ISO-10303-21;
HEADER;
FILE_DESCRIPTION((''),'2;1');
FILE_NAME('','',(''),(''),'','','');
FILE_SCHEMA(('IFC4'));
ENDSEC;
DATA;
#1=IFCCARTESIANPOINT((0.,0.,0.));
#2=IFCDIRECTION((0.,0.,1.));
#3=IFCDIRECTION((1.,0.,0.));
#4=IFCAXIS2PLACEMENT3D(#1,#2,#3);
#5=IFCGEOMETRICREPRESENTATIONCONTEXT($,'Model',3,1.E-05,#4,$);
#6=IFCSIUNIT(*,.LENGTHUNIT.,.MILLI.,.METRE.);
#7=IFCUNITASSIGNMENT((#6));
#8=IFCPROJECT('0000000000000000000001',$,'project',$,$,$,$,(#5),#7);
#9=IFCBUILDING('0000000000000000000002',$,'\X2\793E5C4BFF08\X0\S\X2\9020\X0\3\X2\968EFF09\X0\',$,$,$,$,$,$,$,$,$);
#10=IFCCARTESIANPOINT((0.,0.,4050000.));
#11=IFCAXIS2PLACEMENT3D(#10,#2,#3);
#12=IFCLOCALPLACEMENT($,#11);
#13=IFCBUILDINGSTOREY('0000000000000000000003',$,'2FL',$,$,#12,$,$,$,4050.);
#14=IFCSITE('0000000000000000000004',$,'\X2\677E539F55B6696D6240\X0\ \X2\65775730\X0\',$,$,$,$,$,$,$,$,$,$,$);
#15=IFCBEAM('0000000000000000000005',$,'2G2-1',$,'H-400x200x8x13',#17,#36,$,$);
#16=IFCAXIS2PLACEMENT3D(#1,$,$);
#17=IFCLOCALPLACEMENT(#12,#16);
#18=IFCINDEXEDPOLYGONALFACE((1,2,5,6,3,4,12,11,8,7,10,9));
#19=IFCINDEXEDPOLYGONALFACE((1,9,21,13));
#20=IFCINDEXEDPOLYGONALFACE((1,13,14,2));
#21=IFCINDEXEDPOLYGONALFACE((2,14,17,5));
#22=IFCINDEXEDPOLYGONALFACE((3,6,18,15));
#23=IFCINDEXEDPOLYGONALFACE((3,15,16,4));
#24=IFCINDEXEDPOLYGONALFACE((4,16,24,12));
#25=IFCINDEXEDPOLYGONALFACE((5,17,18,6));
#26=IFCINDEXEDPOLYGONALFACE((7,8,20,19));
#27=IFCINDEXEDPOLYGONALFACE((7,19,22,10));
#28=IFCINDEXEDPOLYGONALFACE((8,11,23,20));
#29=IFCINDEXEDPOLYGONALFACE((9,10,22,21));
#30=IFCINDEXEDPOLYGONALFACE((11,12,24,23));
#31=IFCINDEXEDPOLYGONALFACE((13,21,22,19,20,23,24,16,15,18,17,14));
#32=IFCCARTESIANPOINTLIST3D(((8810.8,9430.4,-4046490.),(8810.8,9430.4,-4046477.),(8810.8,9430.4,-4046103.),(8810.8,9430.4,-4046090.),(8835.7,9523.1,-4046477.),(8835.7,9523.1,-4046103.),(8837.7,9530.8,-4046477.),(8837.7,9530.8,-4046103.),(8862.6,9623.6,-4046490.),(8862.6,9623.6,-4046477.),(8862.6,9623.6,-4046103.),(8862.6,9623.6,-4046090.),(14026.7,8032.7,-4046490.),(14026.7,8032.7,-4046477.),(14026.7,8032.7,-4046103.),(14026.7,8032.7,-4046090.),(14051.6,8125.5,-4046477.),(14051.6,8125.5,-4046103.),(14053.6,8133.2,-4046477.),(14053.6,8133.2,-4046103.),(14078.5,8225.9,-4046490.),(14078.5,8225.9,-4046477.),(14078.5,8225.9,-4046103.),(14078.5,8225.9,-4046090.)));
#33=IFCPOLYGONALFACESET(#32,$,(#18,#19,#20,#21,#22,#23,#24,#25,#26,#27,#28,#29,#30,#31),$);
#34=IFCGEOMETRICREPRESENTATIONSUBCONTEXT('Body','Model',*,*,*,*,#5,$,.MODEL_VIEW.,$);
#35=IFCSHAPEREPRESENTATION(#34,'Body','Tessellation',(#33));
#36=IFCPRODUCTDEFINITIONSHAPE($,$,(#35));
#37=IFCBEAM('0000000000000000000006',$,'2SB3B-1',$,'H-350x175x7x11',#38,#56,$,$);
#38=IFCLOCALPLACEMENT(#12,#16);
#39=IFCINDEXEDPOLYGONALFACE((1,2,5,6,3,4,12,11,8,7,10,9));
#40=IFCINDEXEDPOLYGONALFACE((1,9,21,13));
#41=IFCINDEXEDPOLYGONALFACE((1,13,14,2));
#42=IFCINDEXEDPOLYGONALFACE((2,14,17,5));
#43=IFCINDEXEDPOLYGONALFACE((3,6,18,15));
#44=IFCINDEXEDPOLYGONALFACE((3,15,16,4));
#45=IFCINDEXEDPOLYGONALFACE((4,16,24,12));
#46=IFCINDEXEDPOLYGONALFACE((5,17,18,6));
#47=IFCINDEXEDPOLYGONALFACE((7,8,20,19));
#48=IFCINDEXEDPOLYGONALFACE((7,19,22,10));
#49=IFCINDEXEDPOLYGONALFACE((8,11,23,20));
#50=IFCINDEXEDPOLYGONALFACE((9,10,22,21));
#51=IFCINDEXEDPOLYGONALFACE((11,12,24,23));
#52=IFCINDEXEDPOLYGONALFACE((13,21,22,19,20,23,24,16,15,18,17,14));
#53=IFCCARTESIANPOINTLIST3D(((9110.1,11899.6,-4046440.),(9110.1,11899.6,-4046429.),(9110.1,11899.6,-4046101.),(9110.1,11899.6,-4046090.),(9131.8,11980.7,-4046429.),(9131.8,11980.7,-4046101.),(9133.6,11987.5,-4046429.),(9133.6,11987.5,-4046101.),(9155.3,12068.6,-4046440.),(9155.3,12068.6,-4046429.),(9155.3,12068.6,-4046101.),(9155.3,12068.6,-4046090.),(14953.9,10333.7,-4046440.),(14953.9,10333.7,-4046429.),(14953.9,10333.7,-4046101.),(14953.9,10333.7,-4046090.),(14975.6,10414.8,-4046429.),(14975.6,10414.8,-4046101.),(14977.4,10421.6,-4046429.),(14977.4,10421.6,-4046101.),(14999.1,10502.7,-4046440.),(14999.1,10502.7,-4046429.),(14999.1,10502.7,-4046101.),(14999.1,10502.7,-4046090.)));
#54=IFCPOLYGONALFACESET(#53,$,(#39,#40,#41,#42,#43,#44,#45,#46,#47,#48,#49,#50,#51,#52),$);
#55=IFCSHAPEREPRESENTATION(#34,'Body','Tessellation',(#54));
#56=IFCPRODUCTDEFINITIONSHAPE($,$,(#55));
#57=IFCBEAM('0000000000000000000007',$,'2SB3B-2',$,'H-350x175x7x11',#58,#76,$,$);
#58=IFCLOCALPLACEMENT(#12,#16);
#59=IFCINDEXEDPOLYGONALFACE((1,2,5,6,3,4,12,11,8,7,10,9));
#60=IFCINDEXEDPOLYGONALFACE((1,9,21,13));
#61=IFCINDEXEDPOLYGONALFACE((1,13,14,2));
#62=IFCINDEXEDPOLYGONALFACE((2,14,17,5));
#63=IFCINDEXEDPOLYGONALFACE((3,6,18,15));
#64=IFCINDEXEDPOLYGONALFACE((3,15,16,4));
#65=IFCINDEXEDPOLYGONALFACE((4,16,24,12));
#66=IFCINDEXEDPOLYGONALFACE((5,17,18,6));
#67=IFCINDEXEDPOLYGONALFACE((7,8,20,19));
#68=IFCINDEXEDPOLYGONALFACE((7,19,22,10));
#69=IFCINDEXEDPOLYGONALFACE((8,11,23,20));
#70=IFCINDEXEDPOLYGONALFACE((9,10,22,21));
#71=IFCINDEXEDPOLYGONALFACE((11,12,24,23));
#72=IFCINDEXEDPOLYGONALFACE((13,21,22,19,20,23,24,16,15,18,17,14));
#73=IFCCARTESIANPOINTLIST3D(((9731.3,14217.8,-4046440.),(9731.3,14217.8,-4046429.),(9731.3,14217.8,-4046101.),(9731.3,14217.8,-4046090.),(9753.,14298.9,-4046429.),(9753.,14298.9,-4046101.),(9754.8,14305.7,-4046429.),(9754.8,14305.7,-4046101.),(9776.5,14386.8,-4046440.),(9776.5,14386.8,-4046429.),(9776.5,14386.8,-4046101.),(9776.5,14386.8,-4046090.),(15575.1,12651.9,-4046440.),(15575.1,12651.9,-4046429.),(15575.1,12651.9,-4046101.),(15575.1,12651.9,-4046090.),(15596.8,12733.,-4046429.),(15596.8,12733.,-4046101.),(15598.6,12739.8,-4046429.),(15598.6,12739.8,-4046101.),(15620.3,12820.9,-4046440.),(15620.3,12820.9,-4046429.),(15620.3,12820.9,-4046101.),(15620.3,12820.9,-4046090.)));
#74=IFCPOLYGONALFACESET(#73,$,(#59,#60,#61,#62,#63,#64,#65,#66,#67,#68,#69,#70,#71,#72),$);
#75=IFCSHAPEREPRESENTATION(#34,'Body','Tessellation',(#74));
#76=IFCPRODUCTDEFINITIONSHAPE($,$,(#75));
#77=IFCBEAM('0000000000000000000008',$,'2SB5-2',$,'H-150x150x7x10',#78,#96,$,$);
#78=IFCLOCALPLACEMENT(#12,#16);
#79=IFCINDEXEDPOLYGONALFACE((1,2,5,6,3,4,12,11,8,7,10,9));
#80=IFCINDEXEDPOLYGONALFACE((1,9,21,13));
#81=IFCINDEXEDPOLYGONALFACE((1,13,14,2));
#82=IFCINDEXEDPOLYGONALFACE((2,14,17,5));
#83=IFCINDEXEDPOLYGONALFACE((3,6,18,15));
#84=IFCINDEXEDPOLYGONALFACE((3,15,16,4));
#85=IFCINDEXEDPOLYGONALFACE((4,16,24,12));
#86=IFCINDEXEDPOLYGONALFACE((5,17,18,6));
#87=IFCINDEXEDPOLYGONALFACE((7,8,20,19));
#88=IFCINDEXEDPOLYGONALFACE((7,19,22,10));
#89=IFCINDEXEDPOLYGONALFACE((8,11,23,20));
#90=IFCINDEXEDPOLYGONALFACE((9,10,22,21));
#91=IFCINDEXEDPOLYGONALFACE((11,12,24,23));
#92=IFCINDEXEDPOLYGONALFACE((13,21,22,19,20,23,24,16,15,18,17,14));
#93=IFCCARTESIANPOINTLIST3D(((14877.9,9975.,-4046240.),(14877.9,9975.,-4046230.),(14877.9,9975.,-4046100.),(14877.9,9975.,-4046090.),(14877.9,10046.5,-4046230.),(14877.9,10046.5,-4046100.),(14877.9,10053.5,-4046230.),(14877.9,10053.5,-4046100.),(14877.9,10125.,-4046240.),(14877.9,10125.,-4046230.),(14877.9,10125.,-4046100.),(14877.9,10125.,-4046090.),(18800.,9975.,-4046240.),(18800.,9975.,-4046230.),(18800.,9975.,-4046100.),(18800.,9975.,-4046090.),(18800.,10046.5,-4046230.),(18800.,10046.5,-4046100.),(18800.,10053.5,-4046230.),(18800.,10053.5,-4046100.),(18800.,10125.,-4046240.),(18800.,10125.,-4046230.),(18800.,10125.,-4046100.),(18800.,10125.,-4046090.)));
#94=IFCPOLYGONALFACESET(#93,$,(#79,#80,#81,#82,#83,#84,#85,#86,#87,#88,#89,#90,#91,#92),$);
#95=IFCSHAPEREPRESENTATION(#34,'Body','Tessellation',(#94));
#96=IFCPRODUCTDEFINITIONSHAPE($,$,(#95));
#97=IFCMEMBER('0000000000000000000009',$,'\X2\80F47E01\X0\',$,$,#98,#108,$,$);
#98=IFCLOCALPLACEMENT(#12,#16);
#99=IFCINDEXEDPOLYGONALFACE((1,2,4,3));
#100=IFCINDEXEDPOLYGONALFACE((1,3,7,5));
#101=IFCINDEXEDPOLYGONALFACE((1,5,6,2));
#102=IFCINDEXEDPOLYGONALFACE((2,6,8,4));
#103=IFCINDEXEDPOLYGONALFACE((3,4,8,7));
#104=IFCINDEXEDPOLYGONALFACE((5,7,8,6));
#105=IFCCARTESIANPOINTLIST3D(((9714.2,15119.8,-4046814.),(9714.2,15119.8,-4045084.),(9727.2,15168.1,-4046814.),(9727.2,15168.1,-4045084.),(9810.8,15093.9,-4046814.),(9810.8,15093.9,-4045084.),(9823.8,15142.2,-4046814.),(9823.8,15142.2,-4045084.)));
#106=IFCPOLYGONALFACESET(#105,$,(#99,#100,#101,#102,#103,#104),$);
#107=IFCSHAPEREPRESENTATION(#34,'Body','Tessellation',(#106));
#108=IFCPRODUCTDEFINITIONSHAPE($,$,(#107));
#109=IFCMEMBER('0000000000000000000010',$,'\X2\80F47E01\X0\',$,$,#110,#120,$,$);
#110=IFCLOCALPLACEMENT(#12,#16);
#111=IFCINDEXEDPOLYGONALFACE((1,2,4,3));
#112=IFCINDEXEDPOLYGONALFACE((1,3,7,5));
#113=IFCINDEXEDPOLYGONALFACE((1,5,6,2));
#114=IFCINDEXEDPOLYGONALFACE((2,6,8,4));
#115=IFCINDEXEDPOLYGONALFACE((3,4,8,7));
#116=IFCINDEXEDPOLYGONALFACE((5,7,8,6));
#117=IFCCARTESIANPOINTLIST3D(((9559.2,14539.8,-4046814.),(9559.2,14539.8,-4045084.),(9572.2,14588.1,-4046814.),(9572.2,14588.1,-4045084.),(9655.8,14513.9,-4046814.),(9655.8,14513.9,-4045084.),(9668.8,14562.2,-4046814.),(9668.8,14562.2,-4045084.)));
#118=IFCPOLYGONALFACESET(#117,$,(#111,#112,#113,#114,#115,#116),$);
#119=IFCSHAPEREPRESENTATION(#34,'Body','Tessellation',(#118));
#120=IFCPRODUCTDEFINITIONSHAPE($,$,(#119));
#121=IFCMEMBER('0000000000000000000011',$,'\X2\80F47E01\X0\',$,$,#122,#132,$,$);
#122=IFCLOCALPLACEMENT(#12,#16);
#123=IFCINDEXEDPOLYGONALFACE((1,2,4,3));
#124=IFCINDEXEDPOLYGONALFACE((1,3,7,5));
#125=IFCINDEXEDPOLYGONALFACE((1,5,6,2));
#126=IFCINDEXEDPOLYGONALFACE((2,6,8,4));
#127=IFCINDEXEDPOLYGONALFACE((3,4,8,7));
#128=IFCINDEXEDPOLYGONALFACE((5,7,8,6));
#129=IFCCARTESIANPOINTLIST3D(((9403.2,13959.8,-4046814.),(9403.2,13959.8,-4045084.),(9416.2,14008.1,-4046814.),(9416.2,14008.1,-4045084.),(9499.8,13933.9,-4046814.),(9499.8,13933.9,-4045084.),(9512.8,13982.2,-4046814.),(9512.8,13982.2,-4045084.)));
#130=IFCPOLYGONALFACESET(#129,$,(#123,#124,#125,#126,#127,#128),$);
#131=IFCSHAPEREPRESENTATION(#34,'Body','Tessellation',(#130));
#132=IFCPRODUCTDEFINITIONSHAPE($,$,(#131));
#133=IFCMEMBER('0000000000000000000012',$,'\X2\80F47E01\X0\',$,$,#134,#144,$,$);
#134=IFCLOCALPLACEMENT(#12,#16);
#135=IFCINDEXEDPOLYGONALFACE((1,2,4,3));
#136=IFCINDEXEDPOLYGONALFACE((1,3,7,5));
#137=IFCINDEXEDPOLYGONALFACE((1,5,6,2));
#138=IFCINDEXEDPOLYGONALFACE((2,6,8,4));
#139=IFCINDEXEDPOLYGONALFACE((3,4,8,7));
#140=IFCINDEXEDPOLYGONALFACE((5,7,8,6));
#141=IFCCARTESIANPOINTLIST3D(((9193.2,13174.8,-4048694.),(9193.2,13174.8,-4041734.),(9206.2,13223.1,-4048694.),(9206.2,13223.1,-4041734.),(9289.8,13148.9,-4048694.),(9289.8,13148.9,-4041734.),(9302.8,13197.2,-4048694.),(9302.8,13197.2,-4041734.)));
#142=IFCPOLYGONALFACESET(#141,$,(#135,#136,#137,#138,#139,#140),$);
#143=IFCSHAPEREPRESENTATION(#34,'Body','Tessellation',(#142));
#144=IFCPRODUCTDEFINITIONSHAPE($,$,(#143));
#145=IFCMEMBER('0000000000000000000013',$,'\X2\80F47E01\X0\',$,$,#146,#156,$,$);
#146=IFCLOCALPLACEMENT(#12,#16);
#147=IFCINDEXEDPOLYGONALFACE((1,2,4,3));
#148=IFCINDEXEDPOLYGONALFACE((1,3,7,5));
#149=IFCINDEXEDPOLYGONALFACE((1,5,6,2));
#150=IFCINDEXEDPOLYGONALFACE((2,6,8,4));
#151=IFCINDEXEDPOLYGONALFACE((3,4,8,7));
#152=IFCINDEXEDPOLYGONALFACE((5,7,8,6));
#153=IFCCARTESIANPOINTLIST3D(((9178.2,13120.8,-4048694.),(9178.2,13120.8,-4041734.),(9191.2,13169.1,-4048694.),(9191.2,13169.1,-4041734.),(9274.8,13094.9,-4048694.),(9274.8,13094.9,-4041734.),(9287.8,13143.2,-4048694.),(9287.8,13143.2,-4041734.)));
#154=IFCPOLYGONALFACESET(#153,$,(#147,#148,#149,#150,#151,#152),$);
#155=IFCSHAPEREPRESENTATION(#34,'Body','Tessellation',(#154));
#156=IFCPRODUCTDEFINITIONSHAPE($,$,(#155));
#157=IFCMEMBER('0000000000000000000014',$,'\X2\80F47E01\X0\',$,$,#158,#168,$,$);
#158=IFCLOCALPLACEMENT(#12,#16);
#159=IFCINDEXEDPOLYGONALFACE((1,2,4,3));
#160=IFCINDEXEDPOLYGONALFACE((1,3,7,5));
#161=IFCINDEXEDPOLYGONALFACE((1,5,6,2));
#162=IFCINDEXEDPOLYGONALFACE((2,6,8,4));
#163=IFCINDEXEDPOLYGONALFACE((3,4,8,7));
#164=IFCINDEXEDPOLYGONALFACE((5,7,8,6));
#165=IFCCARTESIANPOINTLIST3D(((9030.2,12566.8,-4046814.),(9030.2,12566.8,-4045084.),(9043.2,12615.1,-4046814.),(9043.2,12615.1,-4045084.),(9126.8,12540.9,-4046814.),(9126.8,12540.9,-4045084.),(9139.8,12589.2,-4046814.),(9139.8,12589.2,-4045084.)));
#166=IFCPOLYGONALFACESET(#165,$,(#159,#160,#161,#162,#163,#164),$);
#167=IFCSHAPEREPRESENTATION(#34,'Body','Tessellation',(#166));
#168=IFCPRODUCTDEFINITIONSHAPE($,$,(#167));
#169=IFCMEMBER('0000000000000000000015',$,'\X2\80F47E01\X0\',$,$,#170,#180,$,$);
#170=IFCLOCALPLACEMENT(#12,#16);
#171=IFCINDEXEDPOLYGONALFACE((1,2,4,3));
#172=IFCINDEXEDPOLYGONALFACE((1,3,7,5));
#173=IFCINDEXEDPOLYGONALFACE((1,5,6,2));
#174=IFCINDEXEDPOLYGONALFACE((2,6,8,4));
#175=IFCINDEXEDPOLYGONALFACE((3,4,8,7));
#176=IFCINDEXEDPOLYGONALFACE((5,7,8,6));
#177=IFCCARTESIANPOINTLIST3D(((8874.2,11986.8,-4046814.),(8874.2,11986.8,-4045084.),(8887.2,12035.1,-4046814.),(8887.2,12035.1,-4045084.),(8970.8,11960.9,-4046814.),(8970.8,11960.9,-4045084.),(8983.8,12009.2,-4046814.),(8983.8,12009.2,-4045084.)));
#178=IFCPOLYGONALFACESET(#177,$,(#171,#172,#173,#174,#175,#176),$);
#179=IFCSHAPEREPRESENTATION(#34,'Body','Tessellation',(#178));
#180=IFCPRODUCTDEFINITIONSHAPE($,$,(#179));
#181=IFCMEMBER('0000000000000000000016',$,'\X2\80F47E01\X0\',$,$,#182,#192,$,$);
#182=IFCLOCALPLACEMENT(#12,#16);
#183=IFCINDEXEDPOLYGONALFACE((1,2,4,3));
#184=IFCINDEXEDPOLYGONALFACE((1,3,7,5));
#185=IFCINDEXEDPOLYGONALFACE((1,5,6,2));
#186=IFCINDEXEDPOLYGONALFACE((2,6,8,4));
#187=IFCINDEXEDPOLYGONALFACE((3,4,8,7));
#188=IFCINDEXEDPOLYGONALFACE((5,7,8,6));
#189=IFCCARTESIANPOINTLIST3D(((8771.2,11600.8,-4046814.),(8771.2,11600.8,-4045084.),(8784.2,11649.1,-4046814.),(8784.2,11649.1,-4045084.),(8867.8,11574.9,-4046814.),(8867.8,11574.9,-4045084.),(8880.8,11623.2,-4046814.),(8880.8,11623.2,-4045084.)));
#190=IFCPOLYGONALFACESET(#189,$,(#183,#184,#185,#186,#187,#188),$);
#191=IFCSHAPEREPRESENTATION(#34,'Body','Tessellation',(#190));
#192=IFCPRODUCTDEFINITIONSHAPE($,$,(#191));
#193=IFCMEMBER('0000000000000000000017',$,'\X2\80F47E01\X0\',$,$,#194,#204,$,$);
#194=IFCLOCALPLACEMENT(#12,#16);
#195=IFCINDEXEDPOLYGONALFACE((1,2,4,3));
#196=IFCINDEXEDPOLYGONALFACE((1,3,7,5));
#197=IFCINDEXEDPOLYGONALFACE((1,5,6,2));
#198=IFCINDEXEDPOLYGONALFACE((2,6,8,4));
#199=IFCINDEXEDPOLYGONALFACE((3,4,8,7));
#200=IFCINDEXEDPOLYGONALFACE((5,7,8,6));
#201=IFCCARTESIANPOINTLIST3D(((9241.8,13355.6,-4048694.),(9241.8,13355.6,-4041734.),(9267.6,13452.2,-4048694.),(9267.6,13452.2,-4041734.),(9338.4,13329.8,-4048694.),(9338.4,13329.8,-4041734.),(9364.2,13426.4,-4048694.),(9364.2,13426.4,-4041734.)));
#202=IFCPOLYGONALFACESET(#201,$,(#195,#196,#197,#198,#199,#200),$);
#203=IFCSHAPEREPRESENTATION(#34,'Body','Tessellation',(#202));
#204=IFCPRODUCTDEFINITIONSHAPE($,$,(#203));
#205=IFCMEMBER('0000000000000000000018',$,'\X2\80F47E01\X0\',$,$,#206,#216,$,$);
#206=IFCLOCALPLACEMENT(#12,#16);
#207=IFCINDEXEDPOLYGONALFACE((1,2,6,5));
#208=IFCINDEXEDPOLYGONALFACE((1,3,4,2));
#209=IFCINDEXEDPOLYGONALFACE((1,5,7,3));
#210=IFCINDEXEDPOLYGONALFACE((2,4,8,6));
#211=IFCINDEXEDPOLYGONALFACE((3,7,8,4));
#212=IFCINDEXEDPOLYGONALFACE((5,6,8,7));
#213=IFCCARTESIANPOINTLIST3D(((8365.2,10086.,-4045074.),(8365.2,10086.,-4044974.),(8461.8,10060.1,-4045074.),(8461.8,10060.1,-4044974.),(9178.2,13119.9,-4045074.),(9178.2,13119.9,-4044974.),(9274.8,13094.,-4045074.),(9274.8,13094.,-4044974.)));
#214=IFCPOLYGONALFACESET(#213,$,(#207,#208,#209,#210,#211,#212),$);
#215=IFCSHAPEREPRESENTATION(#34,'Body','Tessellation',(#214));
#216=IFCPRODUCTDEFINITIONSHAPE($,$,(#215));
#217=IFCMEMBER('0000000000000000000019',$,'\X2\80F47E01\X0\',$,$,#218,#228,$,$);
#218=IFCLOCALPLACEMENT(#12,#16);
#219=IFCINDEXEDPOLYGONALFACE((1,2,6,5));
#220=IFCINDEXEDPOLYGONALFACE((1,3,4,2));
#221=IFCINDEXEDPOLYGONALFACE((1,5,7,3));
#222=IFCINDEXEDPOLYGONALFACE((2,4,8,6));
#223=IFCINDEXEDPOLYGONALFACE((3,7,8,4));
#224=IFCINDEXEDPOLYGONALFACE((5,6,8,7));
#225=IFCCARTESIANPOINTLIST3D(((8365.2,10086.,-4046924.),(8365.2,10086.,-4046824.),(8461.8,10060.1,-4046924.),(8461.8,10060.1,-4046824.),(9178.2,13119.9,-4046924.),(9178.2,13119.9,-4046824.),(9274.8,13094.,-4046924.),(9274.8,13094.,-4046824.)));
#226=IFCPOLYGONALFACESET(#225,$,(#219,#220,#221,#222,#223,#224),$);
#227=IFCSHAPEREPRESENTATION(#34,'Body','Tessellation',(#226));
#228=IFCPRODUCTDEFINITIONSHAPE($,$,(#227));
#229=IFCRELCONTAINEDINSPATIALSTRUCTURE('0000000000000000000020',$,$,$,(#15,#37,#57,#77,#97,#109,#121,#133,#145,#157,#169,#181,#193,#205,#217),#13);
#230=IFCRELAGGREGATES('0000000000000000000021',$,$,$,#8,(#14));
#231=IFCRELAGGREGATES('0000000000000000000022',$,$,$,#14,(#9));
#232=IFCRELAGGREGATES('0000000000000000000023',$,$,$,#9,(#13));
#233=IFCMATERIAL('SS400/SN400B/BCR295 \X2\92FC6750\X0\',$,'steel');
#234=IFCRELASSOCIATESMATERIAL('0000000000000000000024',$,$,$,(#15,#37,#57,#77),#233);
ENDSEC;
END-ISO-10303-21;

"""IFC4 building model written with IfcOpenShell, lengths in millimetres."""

from ifc_helpers import new_model, si_unit, frame, origin, origin_with_axes, place, context, subcontext, project, spatial, rectangle, i_section, extrude, material, element, save


model = new_model("IFC4")

# Units and contexts
model_context = context("Model", 3, precision=1e-05, world=origin_with_axes())
body_context = subcontext(model_context, "Body", "Model", "MODEL_VIEW")
ifc_project = project(units=[si_unit("LENGTHUNIT", "METRE", prefix="MILLI")], contexts=[model_context])

# Site, building, storey
site = spatial("IfcSite", under=ifc_project, Name="松原営業所 敷地")
building = spatial("IfcBuilding", under=site, Name="社屋（S造3階）")
storey_placement = place(None, frame((0.0, 0.0, 4050000.0), z_axis=(0.0, 0.0, 1.0), x_axis=(1.0, 0.0, 0.0)))
storey = spatial("IfcBuildingStorey", under=building, at=storey_placement, Name="2FL", Elevation=4050.0)

# Beams
ifc_material = material(Name="SS400/SN400B/BCR295 鋼材", Category="steel")
beam_1_placement = place(storey_placement, frame((8836.7, 9527.0, -4046090.0), z_axis=(0.965924, -0.258828, 0.0), x_axis=(0.258828, 0.965924, 0.0)))
element("IfcBeam", 1, at=beam_1_placement, inside=storey, material=ifc_material, Name="2G2-1", ObjectType="H-400x200x8x13", context=body_context, shape_type="SweptSolid", body=[
    extrude(i_section(OverallWidth=200.0, OverallDepth=400.0, WebThickness=8.0, FlangeThickness=13.0), frame((0.0, -200.0, 0.0)), (0.0, 0.0, 1.0), 5399.9),
])
beam_2_placement = place(storey_placement, frame((9132.7, 11984.1, -4046090.0), z_axis=(0.965923, -0.258828, 0.0), x_axis=(0.258828, 0.965923, 0.0)))
element("IfcBeam", 2, at=beam_2_placement, inside=storey, material=ifc_material, Name="2SB3B-1", ObjectType="H-350x175x7x11", context=body_context, shape_type="SweptSolid", body=[
    extrude(i_section(OverallWidth=175.0, OverallDepth=350.0, WebThickness=7.0, FlangeThickness=11.0), frame((0.0, -175.0, 0.0)), (0.0, 0.0, 1.0), 6050.0),
])
beam_3_placement = place(storey_placement, frame((9753.9, 14302.3, -4046090.0), z_axis=(0.965923, -0.258828, 0.0), x_axis=(0.258828, 0.965923, 0.0)))
element("IfcBeam", 3, at=beam_3_placement, inside=storey, material=ifc_material, Name="2SB3B-2", ObjectType="H-350x175x7x11", context=body_context, shape_type="SweptSolid", body=[
    extrude(i_section(OverallWidth=175.0, OverallDepth=350.0, WebThickness=7.0, FlangeThickness=11.0), frame((0.0, -175.0, 0.0)), (0.0, 0.0, 1.0), 6050.0),
])
beam_4_placement = place(storey_placement, frame((14877.9, 10050.0, -4046090.0), z_axis=(1.0, 0.0, 0.0), x_axis=(0.0, 1.0, 0.0)))
element("IfcBeam", 4, at=beam_4_placement, inside=storey, material=ifc_material, Name="2SB5-2", ObjectType="H-150x150x7x10", context=body_context, shape_type="SweptSolid", body=[
    extrude(i_section(OverallWidth=150.0, OverallDepth=150.0, WebThickness=7.0, FlangeThickness=10.0), frame((0.0, -75.0, 0.0)), (0.0, 0.0, 1.0), 3922.1),
])

# Members
for number, where, z_axis, x_axis, name in (
    (5, (9775.5, 15155.1, -4045949.0), (-0.258819, -0.965926, 0.0), (0.965926, -0.258819, 0.0), "胴縁"),
    (6, (9620.5, 14575.1, -4045949.0), (-0.258819, -0.965926, 0.0), (0.965926, -0.258819, 0.0), "胴縁"),
    (7, (9464.5, 13995.1, -4045949.0), (-0.258819, -0.965926, 0.0), (0.965926, -0.258819, 0.0), "胴縁"),
):
    element("IfcMember", number, at=place(storey_placement, frame(where, z_axis=z_axis, x_axis=x_axis)), inside=storey, Name=name, context=body_context, shape_type="SweptSolid", body=[
        extrude(rectangle(XDim=100.0, YDim=1730.0), origin(), (0.0, 0.0, 1.0), 50.0),
    ])
for number, where, z_axis, x_axis, name in (
    (8, (9254.5, 13210.1, -4045214.0), (-0.258819, -0.965926, 0.0), (0.965926, -0.258819, 0.0), "胴縁"),
    (9, (9239.5, 13156.1, -4045214.0), (-0.258819, -0.965926, 0.0), (0.965926, -0.258819, 0.0), "胴縁"),
):
    element("IfcMember", number, at=place(storey_placement, frame(where, z_axis=z_axis, x_axis=x_axis)), inside=storey, Name=name, context=body_context, shape_type="SweptSolid", body=[
        extrude(rectangle(XDim=100.0, YDim=6960.0), origin(), (0.0, 0.0, 1.0), 50.0),
    ])
for number, where, z_axis, x_axis, name in (
    (10, (9091.5, 12602.1, -4045949.0), (-0.258819, -0.965926, 0.0), (0.965926, -0.258819, 0.0), "胴縁"),
    (11, (8935.5, 12022.1, -4045949.0), (-0.258819, -0.965926, 0.0), (0.965926, -0.258819, 0.0), "胴縁"),
    (12, (8832.5, 11636.1, -4045949.0), (-0.258819, -0.965926, 0.0), (0.965926, -0.258819, 0.0), "胴縁"),
):
    element("IfcMember", number, at=place(storey_placement, frame(where, z_axis=z_axis, x_axis=x_axis)), inside=storey, Name=name, context=body_context, shape_type="SweptSolid", body=[
        extrude(rectangle(XDim=100.0, YDim=1730.0), origin(), (0.0, 0.0, 1.0), 50.0),
    ])
member_placement = place(storey_placement, frame((9315.9, 13439.3, -4045214.0), z_axis=(-0.258819, -0.965926, 0.0), x_axis=(0.965926, -0.258819, 0.0)))
element("IfcMember", 13, at=member_placement, inside=storey, Name="胴縁", context=body_context, shape_type="SweptSolid", body=[
    extrude(rectangle(XDim=100.0, YDim=6960.0), origin(), (0.0, 0.0, 1.0), 100.0),
])
for number, where, z_axis, x_axis, name in (
    (14, (9226.5, 13107.0, -4045024.0), (-0.258819, -0.965926, 0.0), (0.965926, -0.258819, 0.0), "胴縁"),
    (15, (9226.5, 13107.0, -4046874.0), (-0.258819, -0.965926, 0.0), (0.965926, -0.258819, 0.0), "胴縁"),
):
    element("IfcMember", number, at=place(storey_placement, frame(where, z_axis=z_axis, x_axis=x_axis)), inside=storey, Name=name, context=body_context, shape_type="SweptSolid", body=[
        extrude(rectangle(XDim=100.0, YDim=100.0), origin(), (0.0, 0.0, 1.0), 3141.0),
    ])

save(model, "model.ifc")
